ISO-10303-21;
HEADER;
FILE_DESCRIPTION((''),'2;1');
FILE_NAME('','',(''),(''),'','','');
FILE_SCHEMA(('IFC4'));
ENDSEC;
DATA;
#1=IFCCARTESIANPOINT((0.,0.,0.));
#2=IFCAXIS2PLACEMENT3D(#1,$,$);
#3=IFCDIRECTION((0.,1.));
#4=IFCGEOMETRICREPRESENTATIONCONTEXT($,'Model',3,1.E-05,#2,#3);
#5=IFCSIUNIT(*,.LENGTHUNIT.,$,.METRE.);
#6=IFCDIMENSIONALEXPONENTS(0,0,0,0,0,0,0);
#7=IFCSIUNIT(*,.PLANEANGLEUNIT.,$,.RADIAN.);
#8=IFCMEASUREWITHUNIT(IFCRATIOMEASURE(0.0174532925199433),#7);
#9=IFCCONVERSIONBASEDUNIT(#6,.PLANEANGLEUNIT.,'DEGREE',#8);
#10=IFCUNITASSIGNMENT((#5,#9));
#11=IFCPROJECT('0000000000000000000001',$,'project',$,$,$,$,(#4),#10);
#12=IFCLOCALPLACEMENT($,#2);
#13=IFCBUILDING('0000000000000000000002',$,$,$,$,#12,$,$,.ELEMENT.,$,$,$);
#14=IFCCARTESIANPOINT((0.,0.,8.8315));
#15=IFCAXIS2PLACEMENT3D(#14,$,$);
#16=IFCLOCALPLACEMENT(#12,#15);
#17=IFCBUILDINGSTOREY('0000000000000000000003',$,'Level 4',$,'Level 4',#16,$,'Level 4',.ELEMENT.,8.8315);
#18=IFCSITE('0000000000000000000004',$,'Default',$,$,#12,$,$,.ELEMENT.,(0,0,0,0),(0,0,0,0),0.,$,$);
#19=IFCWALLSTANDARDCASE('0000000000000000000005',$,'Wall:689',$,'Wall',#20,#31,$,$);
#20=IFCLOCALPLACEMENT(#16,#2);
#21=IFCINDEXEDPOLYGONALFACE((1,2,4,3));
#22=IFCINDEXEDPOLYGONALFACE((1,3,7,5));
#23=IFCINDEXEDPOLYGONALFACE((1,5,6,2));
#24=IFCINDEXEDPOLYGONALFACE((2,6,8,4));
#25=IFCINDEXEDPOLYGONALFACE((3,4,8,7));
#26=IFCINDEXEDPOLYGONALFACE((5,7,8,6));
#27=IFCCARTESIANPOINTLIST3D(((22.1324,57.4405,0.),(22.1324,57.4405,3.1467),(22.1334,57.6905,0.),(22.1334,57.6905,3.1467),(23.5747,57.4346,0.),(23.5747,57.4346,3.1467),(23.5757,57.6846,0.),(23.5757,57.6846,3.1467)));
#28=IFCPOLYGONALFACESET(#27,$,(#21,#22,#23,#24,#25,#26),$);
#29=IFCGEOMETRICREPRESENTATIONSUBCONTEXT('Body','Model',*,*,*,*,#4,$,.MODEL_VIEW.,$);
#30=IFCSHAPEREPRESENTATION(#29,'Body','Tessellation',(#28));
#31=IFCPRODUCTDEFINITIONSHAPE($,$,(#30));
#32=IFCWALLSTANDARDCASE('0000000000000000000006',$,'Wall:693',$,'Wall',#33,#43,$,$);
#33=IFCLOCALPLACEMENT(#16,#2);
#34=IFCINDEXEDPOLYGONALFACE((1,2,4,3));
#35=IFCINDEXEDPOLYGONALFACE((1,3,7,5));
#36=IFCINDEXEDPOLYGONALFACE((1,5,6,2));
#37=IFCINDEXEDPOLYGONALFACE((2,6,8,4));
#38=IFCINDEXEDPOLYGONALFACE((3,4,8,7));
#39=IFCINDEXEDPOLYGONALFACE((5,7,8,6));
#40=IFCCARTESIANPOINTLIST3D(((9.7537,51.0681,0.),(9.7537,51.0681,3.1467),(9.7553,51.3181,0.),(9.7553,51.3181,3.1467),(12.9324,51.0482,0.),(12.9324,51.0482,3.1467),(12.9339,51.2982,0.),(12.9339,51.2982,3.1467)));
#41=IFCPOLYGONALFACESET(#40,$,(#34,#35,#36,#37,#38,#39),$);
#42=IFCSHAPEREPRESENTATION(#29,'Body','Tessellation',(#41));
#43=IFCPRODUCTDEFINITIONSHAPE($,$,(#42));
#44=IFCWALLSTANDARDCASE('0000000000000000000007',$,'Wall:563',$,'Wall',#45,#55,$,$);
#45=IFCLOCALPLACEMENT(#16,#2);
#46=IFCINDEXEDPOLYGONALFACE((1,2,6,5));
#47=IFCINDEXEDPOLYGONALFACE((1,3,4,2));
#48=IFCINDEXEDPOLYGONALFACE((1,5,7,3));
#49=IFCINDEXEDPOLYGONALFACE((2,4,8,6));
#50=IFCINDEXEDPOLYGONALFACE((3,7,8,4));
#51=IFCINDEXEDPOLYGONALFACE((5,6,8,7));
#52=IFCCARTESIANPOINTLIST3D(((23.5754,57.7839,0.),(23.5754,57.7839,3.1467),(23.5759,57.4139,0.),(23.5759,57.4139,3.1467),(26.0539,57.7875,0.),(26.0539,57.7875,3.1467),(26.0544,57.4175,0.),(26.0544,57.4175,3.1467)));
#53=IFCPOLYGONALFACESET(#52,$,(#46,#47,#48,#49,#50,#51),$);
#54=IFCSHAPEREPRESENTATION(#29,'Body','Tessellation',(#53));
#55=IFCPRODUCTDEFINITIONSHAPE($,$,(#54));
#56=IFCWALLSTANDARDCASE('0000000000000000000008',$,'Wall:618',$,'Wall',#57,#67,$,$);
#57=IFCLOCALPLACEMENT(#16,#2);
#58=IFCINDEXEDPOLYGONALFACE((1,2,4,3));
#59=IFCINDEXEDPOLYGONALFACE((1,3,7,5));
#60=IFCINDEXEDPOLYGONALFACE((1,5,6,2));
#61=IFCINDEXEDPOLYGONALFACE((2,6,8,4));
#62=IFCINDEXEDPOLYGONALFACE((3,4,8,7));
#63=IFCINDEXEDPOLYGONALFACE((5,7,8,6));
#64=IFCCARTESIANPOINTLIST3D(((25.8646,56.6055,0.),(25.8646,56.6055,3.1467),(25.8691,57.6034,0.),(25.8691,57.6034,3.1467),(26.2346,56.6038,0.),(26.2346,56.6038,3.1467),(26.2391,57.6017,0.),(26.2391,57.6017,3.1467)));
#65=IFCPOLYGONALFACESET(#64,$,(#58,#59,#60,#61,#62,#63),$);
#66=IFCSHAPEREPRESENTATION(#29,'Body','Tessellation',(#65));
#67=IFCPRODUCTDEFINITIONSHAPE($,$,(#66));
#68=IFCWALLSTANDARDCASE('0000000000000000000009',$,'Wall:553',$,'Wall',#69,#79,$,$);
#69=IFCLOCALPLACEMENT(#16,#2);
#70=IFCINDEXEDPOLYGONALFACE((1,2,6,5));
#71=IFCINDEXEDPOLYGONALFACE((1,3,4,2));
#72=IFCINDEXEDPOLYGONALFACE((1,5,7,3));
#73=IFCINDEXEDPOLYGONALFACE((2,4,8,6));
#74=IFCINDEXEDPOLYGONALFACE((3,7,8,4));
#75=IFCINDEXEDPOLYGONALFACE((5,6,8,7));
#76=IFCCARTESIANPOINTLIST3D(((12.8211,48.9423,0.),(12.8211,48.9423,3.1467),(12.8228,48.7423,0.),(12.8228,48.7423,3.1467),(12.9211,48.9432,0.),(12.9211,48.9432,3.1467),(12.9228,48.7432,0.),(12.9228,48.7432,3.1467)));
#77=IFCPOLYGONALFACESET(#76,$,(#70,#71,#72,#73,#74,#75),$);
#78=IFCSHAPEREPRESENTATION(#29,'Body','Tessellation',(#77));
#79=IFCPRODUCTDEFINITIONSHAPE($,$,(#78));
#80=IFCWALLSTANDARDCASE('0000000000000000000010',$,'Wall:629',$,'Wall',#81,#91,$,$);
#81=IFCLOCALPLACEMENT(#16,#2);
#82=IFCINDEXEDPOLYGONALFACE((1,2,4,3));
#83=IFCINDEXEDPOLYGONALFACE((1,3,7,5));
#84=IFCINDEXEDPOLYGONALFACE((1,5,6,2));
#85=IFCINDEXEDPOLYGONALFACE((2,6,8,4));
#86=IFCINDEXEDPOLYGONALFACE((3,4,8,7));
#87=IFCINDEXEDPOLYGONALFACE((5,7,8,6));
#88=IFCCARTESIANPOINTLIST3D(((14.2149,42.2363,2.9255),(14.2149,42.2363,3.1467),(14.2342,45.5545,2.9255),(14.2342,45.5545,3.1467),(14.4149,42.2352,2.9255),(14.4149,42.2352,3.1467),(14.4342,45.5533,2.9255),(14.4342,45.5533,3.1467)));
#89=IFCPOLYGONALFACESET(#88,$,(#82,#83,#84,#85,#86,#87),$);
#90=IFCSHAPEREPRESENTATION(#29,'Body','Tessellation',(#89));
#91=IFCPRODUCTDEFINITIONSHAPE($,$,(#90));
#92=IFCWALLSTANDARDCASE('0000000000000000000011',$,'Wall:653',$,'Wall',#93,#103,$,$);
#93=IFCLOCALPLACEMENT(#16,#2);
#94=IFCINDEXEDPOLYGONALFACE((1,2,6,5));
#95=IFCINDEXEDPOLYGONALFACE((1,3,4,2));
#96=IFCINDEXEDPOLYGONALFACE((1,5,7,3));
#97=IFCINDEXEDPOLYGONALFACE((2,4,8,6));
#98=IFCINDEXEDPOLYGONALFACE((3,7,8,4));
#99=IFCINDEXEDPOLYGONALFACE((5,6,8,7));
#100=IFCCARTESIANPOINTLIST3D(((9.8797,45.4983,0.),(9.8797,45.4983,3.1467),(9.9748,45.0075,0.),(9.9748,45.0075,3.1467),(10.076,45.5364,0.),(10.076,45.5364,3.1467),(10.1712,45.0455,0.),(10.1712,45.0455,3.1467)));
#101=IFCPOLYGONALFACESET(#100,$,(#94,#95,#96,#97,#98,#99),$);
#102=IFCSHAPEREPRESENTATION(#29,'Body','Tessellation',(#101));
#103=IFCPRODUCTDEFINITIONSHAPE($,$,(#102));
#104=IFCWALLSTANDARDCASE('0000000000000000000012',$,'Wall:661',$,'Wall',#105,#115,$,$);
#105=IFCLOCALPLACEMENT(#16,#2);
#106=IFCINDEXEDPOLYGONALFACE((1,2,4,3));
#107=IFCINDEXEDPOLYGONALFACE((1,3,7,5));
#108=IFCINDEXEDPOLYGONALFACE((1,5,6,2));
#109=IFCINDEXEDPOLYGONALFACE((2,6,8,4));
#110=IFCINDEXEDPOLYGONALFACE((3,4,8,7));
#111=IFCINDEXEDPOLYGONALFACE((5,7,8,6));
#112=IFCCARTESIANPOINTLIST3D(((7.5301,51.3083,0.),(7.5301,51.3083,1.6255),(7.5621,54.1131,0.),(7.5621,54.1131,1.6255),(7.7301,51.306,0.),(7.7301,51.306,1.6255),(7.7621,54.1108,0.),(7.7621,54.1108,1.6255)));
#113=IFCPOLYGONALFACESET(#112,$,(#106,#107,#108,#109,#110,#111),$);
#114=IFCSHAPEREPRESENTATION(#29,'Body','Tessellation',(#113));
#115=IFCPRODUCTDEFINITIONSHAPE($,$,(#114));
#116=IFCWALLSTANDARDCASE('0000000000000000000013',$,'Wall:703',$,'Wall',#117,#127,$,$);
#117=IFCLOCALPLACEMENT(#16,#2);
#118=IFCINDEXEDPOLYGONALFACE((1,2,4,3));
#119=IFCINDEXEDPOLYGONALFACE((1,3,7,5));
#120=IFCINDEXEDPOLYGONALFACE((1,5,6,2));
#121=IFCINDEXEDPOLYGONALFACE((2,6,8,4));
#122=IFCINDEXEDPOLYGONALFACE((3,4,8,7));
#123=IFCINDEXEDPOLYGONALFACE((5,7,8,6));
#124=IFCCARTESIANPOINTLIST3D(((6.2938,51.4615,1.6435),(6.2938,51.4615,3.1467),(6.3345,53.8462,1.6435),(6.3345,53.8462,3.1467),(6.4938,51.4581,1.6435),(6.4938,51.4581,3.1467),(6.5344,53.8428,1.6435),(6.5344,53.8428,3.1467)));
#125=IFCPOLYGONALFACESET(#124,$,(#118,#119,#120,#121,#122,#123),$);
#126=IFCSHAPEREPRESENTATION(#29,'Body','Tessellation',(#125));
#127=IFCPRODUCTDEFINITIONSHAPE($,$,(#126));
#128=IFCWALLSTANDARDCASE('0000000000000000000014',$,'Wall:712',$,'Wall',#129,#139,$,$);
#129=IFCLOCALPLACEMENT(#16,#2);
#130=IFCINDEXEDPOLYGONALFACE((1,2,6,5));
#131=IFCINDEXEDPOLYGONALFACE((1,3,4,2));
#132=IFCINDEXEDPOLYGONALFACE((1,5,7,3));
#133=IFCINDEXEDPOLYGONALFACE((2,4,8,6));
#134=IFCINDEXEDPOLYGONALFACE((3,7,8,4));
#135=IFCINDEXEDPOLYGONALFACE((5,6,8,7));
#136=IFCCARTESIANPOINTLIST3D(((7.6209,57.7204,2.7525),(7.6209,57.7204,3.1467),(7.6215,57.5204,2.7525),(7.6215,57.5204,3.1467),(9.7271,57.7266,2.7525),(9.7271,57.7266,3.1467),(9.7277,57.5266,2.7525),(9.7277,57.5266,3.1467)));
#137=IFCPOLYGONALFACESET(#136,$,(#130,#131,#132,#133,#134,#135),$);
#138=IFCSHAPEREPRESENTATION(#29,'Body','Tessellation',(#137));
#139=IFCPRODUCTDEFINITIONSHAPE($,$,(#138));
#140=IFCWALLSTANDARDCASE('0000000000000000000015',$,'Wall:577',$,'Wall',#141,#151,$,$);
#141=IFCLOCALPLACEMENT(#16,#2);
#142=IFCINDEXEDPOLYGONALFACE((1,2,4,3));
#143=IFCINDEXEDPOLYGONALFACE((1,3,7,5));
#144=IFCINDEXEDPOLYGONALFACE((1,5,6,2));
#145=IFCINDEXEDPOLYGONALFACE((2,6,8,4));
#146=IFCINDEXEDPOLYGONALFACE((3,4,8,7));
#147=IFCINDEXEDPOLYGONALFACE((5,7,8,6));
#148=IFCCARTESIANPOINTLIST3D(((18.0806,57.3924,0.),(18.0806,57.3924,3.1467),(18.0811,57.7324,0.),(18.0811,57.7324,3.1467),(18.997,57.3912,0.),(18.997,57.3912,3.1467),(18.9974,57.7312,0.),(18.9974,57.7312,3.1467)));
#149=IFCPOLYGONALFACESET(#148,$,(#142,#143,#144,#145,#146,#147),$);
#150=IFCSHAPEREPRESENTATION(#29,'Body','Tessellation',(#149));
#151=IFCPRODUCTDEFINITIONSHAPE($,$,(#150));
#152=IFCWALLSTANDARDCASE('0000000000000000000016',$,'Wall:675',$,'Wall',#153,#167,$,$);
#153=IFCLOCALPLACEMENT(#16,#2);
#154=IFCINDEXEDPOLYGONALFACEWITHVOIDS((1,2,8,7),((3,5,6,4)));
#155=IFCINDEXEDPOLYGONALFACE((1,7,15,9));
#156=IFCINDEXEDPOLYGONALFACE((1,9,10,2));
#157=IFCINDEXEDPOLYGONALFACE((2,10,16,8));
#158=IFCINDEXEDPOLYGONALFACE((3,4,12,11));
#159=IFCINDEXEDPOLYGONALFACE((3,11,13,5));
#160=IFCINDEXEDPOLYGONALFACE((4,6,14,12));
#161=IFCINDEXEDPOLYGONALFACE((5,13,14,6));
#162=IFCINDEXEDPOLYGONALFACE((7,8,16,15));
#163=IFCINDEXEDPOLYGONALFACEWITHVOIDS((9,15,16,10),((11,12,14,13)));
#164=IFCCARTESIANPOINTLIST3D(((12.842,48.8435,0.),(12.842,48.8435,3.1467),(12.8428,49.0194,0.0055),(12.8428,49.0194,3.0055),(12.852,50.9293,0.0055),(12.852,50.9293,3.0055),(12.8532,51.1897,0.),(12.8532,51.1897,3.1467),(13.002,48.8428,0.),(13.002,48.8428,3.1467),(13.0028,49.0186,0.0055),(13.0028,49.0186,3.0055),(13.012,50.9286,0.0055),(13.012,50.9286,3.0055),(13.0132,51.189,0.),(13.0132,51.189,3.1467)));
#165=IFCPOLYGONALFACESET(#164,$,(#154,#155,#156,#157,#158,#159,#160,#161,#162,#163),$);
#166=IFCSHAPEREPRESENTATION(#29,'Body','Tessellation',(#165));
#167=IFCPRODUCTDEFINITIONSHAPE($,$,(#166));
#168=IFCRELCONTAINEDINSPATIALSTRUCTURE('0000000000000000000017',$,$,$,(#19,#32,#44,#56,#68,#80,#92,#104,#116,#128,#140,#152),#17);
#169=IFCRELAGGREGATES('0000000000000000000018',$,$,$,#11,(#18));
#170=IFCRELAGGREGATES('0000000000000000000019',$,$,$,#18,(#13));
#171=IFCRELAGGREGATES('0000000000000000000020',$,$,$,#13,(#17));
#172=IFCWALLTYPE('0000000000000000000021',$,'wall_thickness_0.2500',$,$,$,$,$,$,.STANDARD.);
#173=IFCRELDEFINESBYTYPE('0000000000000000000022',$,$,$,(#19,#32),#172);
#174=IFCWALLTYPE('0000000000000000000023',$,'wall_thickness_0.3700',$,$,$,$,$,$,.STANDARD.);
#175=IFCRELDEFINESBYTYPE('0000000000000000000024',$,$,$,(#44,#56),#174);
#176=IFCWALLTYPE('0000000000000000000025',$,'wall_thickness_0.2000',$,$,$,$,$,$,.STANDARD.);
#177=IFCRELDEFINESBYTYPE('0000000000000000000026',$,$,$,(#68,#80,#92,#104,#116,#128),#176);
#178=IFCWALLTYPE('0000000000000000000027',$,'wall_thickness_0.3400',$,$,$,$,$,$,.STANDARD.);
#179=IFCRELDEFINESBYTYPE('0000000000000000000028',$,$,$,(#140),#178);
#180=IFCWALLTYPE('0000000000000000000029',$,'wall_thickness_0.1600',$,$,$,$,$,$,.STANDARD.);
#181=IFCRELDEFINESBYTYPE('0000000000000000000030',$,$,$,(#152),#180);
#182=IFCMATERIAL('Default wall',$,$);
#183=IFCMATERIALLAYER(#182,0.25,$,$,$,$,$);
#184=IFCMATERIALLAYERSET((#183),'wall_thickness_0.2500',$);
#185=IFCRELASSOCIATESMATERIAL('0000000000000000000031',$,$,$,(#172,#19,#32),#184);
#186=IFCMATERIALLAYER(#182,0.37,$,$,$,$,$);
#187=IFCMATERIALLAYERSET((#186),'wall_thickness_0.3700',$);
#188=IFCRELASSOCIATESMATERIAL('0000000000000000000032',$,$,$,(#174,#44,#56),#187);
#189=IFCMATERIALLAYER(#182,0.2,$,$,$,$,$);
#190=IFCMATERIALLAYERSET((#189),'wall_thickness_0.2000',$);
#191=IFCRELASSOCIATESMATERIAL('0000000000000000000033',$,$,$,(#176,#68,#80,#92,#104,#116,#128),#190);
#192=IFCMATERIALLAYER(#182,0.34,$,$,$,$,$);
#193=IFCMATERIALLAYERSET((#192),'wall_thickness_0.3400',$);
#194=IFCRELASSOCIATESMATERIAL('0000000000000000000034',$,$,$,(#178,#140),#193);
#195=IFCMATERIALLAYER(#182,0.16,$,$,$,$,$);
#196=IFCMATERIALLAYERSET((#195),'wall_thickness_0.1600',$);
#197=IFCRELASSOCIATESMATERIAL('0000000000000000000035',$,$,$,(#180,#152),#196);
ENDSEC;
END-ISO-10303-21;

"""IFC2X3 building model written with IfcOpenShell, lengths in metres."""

from ifc_helpers import new_model, entity, si_unit, converted_unit, direction, frame, frame_2d, origin, place, context, subcontext, project, spatial, polyline, rectangle, outline, extrude, material, layer, layer_set, layer_usage, type_object, element, save


model = new_model("IFC2X3")

# Units and contexts
model_context = context("Model", 3, precision=1e-05, world=origin(), true_north=direction((0.0, 1.0)))
body_context = subcontext(model_context, "Body", "Model", "MODEL_VIEW")
ifc_project = project(units=[si_unit("LENGTHUNIT", "METRE"), converted_unit("PLANEANGLEUNIT", "DEGREE", entity("IfcRatioMeasure", 0.0174532925199433), si_unit("PLANEANGLEUNIT", "RADIAN"), dimensions=[0, 0, 0, 0, 0, 0, 0])], contexts=[model_context])

# Site, building, storey
placement_1 = place(None, origin())
site = spatial("IfcSite", under=ifc_project, at=placement_1, Name="Default", CompositionType="ELEMENT", RefLatitude=(0, 0, 0, 0), RefLongitude=(0, 0, 0, 0), RefElevation=0.0)
building = spatial("IfcBuilding", under=site, at=placement_1, CompositionType="ELEMENT")
storey_placement = place(placement_1, frame((0.0, 0.0, 8.8315)))
storey = spatial("IfcBuildingStorey", under=building, at=storey_placement, Name="Level 4", ObjectType="Level 4", LongName="Level 4", CompositionType="ELEMENT", Elevation=8.8315)

# Shared definitions
ifc_material_1 = material(Name="Default wall")

# Walls
ifc_layer_1 = layer(ifc_material_1, 0.25)
ifc_layer_set_1 = layer_set([ifc_layer_1], Name="wall_thickness_0.2500")
ifc_layer_usage_1 = layer_usage(ifc_layer_set_1, "AXIS2", "POSITIVE", -0.125)
wall_type_1 = type_object("IfcWallType", Name="wall_thickness_0.2500", PredefinedType="STANDARD", material=ifc_layer_set_1)
wall_1_placement = place(storey_placement, frame((23.5752, 57.5596, 0.0), z_axis=(0.0, 0.0, 1.0), x_axis=(-0.999992, 0.004094, 0.0)))
element("IfcWallStandardCase", 1, at=wall_1_placement, inside=storey, type_object=wall_type_1, material=ifc_layer_usage_1, Name="Wall:689", ObjectType="Wall", context=body_context, shape_type="SweptSolid", body=[
    extrude(outline(polyline([(1.4424, -0.125), (1.4424, 0.125), (0.0, 0.125), (0.0, -0.125), (1.4424, -0.125)])), origin(), (0.0, 0.0, 1.0), 3.1467),
])
wall_2_placement = place(storey_placement, frame((9.7545, 51.1931, 0.0), z_axis=(0.0, 0.0, 1.0), x_axis=(0.99998, -0.006273, 0.0)))
element("IfcWallStandardCase", 2, at=wall_2_placement, inside=storey, type_object=wall_type_1, material=ifc_layer_usage_1, Name="Wall:693", ObjectType="Wall", context=body_context, shape_type="SweptSolid", body=[
    extrude(outline(polyline([(3.1787, -0.125), (3.1787, 0.125), (0.0, 0.125), (0.0, -0.125), (3.1787, -0.125)])), origin(), (0.0, 0.0, 1.0), 3.1467),
])
ifc_layer_2 = layer(ifc_material_1, 0.37)
ifc_layer_set_2 = layer_set([ifc_layer_2], Name="wall_thickness_0.3700")
ifc_layer_usage_2 = layer_usage(ifc_layer_set_2, "AXIS2", "POSITIVE", -0.185)
wall_type_2 = type_object("IfcWallType", Name="wall_thickness_0.3700", PredefinedType="STANDARD", material=ifc_layer_set_2)
wall_3_placement = place(storey_placement, frame((23.5757, 57.5989, 0.0), z_axis=(0.0, 0.0, 1.0), x_axis=(0.999999, 0.001456, 0.0)))
element("IfcWallStandardCase", 3, at=wall_3_placement, inside=storey, type_object=wall_type_2, material=ifc_layer_usage_2, Name="Wall:563", ObjectType="Wall", context=body_context, shape_type="SweptSolid", body=[
    extrude(outline(polyline([(2.4785, -0.185), (2.4785, 0.185), (0.0, 0.185), (0.0, -0.185), (2.4785, -0.185)])), origin(), (0.0, 0.0, 1.0), 3.1467),
])
wall_4_placement = place(storey_placement, frame((26.0541, 57.6025, 0.0), z_axis=(0.0, 0.0, 1.0), x_axis=(-0.004551, -0.99999, 0.0)))
element("IfcWallStandardCase", 4, at=wall_4_placement, inside=storey, type_object=wall_type_2, material=ifc_layer_usage_2, Name="Wall:618", ObjectType="Wall", context=body_context, shape_type="SweptSolid", body=[
    extrude(outline(polyline([(0.9979, -0.185), (0.9979, 0.185), (0.0, 0.185), (0.0, -0.185), (0.9979, -0.185)])), origin(), (0.0, 0.0, 1.0), 3.1467),
])
ifc_layer_3 = layer(ifc_material_1, 0.2)
ifc_layer_set_3 = layer_set([ifc_layer_3], Name="wall_thickness_0.2000")
ifc_layer_usage_3 = layer_usage(ifc_layer_set_3, "AXIS2", "POSITIVE", -0.1)
wall_type_3 = type_object("IfcWallType", Name="wall_thickness_0.2000", PredefinedType="STANDARD", material=ifc_layer_set_3)
wall_5_placement = place(storey_placement, frame((12.822, 48.8423, 0.0), z_axis=(0.0, 0.0, 1.0), x_axis=(0.999965, 0.008391, 0.0)))
element("IfcWallStandardCase", 5, at=wall_5_placement, inside=storey, type_object=wall_type_3, material=ifc_layer_usage_3, Name="Wall:553", ObjectType="Wall", context=body_context, shape_type="SweptSolid", body=[
    extrude(outline(polyline([(0.1, -0.1), (0.1, 0.1), (0.0, 0.1), (0.0, -0.1), (0.1, -0.1)])), origin(), (0.0, 0.0, 1.0), 3.1467),
])
placement_2 = place(placement_1, frame((0.0, 0.0, 11.757)))
wall_6_placement = place(placement_2, frame((14.3342, 45.5539, 0.0), z_axis=(0.0, 0.0, 1.0), x_axis=(-0.005803, -0.999983, 0.0)))
element("IfcWallStandardCase", 6, at=wall_6_placement, inside=storey, type_object=wall_type_3, material=ifc_layer_usage_3, Name="Wall:629", ObjectType="Wall", context=body_context, shape_type="SweptSolid", body=[
    extrude(outline(polyline([(3.3182, -0.1), (3.3182, 0.1), (0.0, 0.1), (0.0, -0.1), (3.3182, -0.1)])), origin(), (0.0, 0.0, 1.0), 0.2212),
])
wall_7_placement = place(storey_placement, frame((9.9779, 45.5174, 0.0), z_axis=(0.0, 0.0, 1.0), x_axis=(0.190276, -0.981731, 0.0)))
element("IfcWallStandardCase", 7, at=wall_7_placement, inside=storey, type_object=wall_type_3, material=ifc_layer_usage_3, Name="Wall:653", ObjectType="Wall", context=body_context, shape_type="SweptSolid", body=[
    extrude(outline(polyline([(0.5, -0.1), (0.5, 0.1), (0.0, 0.1), (0.0, -0.1), (0.5, -0.1)])), origin(), (0.0, 0.0, 1.0), 3.1467),
])
wall_8_placement = place(storey_placement, frame((7.6301, 51.3071, 0.0), z_axis=(0.0, 0.0, 1.0), x_axis=(0.011421, 0.999935, 0.0)))
element("IfcWallStandardCase", 8, at=wall_8_placement, inside=storey, type_object=wall_type_3, material=ifc_layer_usage_3, Name="Wall:661", ObjectType="Wall", context=body_context, shape_type="SweptSolid", body=[
    extrude(outline(polyline([(2.805, -0.1), (2.805, 0.1), (0.0, 0.1), (0.0, -0.1), (2.805, -0.1)])), origin(), (0.0, 0.0, 1.0), 1.6255),
])
placement_3 = place(placement_1, frame((0.0, 0.0, 10.475)))
wall_9_placement = place(placement_3, frame((6.3938, 51.4598, 0.0), z_axis=(0.0, 0.0, 1.0), x_axis=(0.017037, 0.999855, 0.0)))
element("IfcWallStandardCase", 9, at=wall_9_placement, inside=storey, type_object=wall_type_3, material=ifc_layer_usage_3, Name="Wall:703", ObjectType="Wall", context=body_context, shape_type="SweptSolid", body=[
    extrude(outline(polyline([(2.385, -0.1), (2.385, 0.1), (0.0, 0.1), (0.0, -0.1), (2.385, -0.1)])), origin(), (0.0, 0.0, 1.0), 1.5032),
])
placement_4 = place(placement_1, frame((0.0, 0.0, 11.584)))
wall_10_placement = place(placement_4, frame((7.6212, 57.6204, 0.0), z_axis=(0.0, 0.0, 1.0), x_axis=(0.999996, 0.002925, 0.0)))
element("IfcWallStandardCase", 10, at=wall_10_placement, inside=storey, type_object=wall_type_3, material=ifc_layer_usage_3, Name="Wall:712", ObjectType="Wall", context=body_context, shape_type="SweptSolid", body=[
    extrude(outline(polyline([(2.1062, -0.1), (2.1062, 0.1), (0.0, 0.1), (0.0, -0.1), (2.1062, -0.1)])), origin(), (0.0, 0.0, 1.0), 0.3942),
])
ifc_layer_4 = layer(ifc_material_1, 0.34)
ifc_layer_set_4 = layer_set([ifc_layer_4], Name="wall_thickness_0.3400")
ifc_layer_usage_4 = layer_usage(ifc_layer_set_4, "AXIS2", "POSITIVE", -0.17)
wall_type_4 = type_object("IfcWallType", Name="wall_thickness_0.3400", PredefinedType="STANDARD", material=ifc_layer_set_4)
wall_11_placement = place(storey_placement, frame((18.0809, 57.5624, 0.0), z_axis=(0.0, 0.0, 1.0), x_axis=(0.999999, -0.001303, 0.0)))
element("IfcWallStandardCase", 11, at=wall_11_placement, inside=storey, type_object=wall_type_4, material=ifc_layer_usage_4, Name="Wall:577", ObjectType="Wall", context=body_context, shape_type="SweptSolid", body=[
    extrude(outline(polyline([(0.9164, -0.17), (0.9164, 0.17), (0.0, 0.17), (0.0, -0.17), (0.9164, -0.17)])), origin(), (0.0, 0.0, 1.0), 3.1467),
])

# Wall, opening
ifc_layer_5 = layer(ifc_material_1, 0.16)
ifc_layer_set_5 = layer_set([ifc_layer_5], Name="wall_thickness_0.1600")
ifc_layer_usage_5 = layer_usage(ifc_layer_set_5, "AXIS2", "POSITIVE", -0.08)
wall_type_5 = type_object("IfcWallType", Name="wall_thickness_0.1600", PredefinedType="STANDARD", material=ifc_layer_set_5)
wall_12_placement = place(storey_placement, frame((12.9332, 51.1894, 0.0), z_axis=(0.0, 0.0, 1.0), x_axis=(-0.004802, -0.999988, 0.0)))
wall_12 = element("IfcWallStandardCase", 12, at=wall_12_placement, inside=storey, type_object=wall_type_5, material=ifc_layer_usage_5, Name="Wall:675", ObjectType="Wall", context=body_context, shape_type="SweptSolid", body=[
    extrude(outline(polyline([(2.3462, -0.08), (2.3462, 0.08), (0.0, 0.08), (0.0, -0.08), (2.3462, -0.08)])), origin(), (0.0, 0.0, 1.0), 3.1467),
])
opening_1_placement = place(wall_12_placement, frame((0.2604, -0.08, 0.0055)))
element("IfcOpeningElement", 13, at=opening_1_placement, cuts=wall_12, ObjectType="Opening", context=body_context, shape_type="SweptSolid", body=[
    extrude(rectangle(XDim=1.91, YDim=3.0, at=frame_2d((1.5, 0.955), x_axis=(0.0, 1.0))), frame((0.0, 0.0, 0.0), z_axis=(0.0, 1.0, 0.0), x_axis=(0.0, 0.0, 1.0)), (0.0, 0.0, 1.0), 0.16),
])

save(model, "model.ifc")
